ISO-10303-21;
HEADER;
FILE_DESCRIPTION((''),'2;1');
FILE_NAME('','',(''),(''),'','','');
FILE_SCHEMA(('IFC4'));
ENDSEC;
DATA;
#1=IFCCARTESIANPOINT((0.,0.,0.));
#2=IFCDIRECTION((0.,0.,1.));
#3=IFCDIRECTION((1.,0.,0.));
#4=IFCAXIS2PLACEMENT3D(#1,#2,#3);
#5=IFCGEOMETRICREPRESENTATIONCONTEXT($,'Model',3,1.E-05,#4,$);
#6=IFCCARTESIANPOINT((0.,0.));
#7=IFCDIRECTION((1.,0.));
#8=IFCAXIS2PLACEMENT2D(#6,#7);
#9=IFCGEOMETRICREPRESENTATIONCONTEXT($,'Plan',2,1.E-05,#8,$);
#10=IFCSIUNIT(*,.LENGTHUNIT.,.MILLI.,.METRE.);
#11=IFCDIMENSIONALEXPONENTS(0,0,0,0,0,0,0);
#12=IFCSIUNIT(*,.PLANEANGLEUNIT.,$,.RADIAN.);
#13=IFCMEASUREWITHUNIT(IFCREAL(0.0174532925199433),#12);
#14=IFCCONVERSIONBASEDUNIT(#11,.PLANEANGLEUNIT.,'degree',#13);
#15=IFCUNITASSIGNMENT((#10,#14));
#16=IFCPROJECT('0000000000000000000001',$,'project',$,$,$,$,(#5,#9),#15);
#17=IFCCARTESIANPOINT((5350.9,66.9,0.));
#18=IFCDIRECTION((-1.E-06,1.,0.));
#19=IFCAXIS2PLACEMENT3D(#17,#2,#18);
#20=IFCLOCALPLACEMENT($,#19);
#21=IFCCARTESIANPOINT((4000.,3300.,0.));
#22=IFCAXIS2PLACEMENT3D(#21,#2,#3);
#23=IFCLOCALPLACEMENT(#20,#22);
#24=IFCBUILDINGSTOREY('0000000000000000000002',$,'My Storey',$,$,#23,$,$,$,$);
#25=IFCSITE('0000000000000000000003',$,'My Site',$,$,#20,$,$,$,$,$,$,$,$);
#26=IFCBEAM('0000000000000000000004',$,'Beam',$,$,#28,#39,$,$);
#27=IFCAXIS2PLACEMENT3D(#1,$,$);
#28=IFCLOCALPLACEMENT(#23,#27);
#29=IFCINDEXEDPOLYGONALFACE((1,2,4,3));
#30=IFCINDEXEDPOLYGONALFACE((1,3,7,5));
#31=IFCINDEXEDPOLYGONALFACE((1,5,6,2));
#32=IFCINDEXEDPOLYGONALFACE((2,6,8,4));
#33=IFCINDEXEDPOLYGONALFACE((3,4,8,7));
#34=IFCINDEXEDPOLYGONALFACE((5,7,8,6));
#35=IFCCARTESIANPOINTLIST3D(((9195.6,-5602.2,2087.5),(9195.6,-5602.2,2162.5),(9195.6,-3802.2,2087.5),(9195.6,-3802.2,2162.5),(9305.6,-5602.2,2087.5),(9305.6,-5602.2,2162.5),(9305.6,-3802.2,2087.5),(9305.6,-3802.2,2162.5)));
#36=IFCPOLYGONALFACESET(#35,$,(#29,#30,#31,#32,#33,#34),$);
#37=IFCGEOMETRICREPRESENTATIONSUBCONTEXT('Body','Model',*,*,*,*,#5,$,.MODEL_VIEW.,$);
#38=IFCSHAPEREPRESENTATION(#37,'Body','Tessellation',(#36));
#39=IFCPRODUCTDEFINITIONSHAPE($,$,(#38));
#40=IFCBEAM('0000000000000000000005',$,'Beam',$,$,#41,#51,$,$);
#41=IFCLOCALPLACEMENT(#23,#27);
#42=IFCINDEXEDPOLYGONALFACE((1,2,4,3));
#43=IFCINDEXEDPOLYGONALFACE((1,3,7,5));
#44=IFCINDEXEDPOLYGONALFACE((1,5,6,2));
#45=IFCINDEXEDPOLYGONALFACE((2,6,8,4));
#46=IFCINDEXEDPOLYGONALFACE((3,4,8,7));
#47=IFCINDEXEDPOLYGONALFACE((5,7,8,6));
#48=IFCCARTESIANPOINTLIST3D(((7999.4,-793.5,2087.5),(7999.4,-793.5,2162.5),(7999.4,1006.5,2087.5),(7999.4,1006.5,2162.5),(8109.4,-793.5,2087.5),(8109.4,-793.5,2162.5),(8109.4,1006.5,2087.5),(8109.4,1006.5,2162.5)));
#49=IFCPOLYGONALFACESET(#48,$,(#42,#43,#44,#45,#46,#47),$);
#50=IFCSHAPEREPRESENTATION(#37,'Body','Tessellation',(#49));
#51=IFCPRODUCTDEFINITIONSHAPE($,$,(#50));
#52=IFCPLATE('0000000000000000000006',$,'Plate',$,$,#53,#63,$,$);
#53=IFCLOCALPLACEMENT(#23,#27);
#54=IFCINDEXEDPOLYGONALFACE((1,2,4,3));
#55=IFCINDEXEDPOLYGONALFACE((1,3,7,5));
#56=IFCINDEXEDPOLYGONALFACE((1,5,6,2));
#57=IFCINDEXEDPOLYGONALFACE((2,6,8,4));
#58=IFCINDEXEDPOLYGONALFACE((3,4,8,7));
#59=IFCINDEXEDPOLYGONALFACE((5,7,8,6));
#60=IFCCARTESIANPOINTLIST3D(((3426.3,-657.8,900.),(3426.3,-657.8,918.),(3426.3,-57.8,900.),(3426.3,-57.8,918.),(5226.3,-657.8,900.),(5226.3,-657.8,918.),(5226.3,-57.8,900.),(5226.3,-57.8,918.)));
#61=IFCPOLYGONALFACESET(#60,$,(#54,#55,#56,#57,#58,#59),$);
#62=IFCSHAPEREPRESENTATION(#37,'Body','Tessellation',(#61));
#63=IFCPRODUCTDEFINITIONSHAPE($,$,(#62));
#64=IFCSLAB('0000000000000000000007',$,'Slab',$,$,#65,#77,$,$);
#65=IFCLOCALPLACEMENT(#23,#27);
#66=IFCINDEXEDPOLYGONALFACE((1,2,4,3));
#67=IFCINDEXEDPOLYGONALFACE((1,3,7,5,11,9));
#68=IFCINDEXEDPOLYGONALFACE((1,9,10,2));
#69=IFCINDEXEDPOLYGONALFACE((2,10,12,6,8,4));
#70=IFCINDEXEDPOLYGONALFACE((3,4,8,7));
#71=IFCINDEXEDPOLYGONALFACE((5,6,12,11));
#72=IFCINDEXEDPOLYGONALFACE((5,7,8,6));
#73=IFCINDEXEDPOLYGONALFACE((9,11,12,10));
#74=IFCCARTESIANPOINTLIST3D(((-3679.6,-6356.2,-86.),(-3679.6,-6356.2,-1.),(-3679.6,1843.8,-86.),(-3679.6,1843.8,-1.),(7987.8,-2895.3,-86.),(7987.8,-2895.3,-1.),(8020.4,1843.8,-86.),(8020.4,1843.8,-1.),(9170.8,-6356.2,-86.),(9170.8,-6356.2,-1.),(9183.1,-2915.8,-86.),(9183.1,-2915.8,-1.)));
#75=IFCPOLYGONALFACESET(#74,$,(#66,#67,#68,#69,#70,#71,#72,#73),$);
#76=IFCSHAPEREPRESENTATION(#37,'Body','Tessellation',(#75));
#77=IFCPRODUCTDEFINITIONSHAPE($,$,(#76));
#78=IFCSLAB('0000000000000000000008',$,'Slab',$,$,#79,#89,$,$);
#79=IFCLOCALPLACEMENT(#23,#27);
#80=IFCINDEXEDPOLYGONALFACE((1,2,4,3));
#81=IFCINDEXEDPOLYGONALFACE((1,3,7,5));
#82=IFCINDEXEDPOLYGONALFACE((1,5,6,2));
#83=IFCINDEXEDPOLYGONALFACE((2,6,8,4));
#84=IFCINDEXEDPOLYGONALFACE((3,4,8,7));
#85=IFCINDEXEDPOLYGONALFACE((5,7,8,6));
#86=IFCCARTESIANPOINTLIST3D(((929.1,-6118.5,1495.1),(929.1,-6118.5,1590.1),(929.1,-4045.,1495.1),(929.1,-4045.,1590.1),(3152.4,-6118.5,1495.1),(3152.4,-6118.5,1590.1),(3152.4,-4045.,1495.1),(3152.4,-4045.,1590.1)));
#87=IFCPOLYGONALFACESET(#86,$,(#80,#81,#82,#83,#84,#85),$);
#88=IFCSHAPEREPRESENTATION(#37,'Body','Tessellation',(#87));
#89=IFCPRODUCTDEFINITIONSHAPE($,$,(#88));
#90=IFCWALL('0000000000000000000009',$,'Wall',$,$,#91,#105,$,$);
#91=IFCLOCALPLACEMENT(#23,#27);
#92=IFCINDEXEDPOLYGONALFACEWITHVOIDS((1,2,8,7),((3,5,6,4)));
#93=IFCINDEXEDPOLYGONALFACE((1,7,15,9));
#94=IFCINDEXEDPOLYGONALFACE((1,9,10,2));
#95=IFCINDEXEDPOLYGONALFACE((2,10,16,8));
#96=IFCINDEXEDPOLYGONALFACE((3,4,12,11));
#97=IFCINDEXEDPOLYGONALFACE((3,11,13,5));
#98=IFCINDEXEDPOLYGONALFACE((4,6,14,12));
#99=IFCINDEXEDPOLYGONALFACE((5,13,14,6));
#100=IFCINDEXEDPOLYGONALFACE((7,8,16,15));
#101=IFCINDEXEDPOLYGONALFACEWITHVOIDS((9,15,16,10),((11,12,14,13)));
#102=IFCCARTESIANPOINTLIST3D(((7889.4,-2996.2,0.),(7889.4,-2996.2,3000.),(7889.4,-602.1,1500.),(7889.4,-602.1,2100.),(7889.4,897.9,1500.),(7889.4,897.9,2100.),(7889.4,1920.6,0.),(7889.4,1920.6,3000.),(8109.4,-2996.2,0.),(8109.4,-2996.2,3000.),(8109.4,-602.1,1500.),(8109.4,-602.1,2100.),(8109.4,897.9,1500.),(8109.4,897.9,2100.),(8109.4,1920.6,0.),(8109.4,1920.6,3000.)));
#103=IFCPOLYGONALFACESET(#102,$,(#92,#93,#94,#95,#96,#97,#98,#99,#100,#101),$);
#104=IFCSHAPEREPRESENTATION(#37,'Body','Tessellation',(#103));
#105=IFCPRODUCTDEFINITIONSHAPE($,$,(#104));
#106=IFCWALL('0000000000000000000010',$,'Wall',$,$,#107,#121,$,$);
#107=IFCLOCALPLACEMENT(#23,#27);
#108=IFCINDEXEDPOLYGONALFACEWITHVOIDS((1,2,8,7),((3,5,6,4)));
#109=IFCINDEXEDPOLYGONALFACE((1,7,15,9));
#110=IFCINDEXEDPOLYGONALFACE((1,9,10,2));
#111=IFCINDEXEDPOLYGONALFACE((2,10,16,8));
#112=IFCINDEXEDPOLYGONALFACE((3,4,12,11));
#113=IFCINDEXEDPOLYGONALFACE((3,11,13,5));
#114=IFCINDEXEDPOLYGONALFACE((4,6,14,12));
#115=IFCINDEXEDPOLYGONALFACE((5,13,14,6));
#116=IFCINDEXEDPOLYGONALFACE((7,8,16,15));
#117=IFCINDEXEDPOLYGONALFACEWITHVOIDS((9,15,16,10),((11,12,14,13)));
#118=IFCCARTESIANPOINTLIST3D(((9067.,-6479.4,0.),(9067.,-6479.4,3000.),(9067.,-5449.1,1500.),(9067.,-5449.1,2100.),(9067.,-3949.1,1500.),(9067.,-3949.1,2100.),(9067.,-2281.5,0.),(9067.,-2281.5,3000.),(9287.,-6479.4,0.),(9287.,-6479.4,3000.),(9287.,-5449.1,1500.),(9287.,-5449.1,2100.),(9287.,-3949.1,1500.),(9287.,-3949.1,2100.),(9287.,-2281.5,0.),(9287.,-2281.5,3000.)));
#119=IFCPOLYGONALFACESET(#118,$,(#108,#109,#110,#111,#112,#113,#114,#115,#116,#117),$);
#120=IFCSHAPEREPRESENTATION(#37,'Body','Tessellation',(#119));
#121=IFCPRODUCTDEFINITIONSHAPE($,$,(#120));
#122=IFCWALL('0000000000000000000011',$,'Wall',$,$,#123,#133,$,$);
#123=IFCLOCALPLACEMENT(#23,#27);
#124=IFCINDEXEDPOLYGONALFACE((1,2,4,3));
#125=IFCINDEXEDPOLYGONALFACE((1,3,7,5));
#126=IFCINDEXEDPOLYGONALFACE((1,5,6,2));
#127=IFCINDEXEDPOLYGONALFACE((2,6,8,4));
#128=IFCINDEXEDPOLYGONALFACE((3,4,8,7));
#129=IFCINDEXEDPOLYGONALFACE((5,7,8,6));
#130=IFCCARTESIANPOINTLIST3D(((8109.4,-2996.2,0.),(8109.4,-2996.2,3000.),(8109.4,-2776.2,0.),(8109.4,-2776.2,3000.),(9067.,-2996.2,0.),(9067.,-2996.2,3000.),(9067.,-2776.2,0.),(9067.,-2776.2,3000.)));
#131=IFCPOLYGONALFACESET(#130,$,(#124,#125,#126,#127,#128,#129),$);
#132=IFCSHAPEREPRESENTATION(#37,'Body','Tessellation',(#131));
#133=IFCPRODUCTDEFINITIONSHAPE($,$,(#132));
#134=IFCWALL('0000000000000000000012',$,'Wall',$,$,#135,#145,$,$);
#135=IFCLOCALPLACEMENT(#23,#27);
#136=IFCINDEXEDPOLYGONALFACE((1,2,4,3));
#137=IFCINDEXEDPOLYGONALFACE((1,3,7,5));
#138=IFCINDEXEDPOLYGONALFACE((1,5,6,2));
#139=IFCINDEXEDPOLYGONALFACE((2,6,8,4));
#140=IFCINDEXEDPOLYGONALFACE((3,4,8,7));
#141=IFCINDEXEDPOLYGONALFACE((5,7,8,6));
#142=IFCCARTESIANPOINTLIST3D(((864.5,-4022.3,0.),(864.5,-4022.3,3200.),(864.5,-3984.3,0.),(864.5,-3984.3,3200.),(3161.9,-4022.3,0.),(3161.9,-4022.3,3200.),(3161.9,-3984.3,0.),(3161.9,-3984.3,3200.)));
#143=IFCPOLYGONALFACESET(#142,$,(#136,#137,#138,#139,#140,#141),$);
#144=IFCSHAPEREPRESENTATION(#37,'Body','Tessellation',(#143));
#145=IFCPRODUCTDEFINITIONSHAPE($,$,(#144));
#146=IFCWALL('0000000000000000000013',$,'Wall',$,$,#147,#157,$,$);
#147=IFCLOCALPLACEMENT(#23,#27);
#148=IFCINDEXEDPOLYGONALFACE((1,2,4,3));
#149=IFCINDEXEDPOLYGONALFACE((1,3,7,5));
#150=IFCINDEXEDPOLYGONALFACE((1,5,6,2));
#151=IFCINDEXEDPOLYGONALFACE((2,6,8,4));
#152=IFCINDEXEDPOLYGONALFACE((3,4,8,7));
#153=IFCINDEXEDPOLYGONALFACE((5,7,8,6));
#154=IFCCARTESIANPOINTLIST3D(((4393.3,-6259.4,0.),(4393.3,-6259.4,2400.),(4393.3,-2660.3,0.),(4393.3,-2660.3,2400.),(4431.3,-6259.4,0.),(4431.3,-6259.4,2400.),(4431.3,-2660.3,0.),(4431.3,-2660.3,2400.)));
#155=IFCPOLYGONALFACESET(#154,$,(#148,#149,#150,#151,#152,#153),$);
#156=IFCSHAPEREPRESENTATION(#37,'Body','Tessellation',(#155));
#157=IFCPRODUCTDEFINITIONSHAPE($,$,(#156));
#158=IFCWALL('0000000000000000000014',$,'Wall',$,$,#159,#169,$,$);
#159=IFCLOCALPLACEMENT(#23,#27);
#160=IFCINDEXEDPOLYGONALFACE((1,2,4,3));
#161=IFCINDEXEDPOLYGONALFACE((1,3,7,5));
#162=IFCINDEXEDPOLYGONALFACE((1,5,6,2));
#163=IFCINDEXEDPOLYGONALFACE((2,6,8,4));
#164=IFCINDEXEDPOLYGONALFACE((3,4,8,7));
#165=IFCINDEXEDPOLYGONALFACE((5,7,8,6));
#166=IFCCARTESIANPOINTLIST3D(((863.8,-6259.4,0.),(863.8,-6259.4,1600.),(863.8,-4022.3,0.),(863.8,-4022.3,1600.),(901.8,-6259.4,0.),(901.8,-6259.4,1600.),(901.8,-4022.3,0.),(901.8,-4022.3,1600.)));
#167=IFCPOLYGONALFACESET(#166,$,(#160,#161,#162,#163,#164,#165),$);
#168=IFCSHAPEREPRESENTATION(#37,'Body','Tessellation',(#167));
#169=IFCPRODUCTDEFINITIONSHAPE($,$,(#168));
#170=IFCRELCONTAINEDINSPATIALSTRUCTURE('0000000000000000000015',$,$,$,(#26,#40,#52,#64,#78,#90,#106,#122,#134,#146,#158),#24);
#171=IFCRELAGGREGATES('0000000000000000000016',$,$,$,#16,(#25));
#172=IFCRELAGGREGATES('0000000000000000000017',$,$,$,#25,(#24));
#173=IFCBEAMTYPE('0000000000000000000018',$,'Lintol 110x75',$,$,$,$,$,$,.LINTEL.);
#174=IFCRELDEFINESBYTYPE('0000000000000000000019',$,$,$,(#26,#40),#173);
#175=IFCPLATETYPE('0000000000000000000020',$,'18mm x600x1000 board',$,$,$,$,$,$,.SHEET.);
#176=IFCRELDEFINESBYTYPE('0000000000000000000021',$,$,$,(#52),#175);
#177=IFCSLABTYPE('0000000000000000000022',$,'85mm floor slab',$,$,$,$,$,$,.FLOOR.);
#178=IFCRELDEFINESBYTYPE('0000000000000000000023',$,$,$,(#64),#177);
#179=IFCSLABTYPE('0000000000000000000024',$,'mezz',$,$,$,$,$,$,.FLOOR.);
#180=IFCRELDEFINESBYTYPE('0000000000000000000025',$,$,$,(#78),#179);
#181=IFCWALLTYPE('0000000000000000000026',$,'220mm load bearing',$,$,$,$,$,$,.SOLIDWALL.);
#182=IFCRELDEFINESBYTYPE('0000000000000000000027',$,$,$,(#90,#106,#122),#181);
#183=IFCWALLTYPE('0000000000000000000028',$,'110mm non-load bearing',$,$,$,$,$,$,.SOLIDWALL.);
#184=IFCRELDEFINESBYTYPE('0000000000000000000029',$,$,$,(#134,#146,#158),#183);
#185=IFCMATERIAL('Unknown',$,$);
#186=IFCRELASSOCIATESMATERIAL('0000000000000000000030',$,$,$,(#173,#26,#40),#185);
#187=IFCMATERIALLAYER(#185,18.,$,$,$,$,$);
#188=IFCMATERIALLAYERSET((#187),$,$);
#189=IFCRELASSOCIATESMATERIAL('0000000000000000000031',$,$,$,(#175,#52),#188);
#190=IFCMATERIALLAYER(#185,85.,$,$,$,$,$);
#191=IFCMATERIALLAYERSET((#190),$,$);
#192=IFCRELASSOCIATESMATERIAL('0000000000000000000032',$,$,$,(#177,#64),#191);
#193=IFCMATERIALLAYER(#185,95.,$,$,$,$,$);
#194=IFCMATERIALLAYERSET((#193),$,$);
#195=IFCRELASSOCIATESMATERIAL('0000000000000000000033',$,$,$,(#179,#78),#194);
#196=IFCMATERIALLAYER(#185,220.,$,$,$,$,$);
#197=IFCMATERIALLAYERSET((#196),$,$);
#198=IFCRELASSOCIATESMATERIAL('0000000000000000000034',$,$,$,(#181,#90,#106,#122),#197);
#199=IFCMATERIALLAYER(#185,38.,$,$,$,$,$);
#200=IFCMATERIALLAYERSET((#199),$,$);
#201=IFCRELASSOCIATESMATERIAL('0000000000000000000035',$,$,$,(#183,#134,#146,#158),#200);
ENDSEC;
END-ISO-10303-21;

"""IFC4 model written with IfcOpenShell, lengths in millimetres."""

from ifc_helpers import new_model, entity, si_unit, converted_unit, frame, origin_with_axes, origin_2d_with_axis, place, context, subcontext, project, spatial, line, indexed_curve, rectangle, outline, extrude, source, transform, mapped, material, layer, layer_set, layer_usage, material_profile, profile_set, profile_usage, type_object, element, save


model = new_model("IFC4")

# Units and contexts
model_context = context("Model", 3, precision=1e-05, world=origin_with_axes())
plan_context = context("Plan", 2, precision=1e-05, world=origin_2d_with_axis())
body_context = subcontext(model_context, "Body", "Model", "MODEL_VIEW")
ifc_project = project(units=[si_unit("LENGTHUNIT", "METRE", prefix="MILLI"), converted_unit("PLANEANGLEUNIT", "degree", entity("IfcReal", 0.0174532925199433), si_unit("PLANEANGLEUNIT", "RADIAN"), dimensions=[0, 0, 0, 0, 0, 0, 0])], contexts=[model_context, plan_context])

# Site, storey
site_placement = place(None, frame((5350.9, 66.9, 0.0), z_axis=(0.0, 0.0, 1.0), x_axis=(-0.000001, 1.0, 0.0)))
site = spatial("IfcSite", under=ifc_project, at=site_placement, Name="My Site")
storey_placement = place(site_placement, frame((4000.0, 3300.0, 0.0), z_axis=(0.0, 0.0, 1.0), x_axis=(1.0, 0.0, 0.0)))
storey = spatial("IfcBuildingStorey", under=site, at=storey_placement, Name="My Storey")

# Beams
ifc_material = material(Name="Unknown")
ifc_material_profile = material_profile(ifc_material, rectangle(XDim=110.0, YDim=75.0))
ifc_profile_set = profile_set([ifc_material_profile])
ifc_profile_usage_1 = profile_usage(ifc_profile_set, cardinal=5)
beam_type = type_object("IfcBeamType", Name="Lintol 110x75", PredefinedType="LINTEL", material=ifc_profile_set)
beam_1_placement = place(storey_placement, frame((9250.6, -3802.2, 2125.0), z_axis=(-0.000001, -1.0, 0.0), x_axis=(1.0, -0.000001, 0.0)))
element("IfcBeam", 1, at=beam_1_placement, inside=storey, type_object=beam_type, material=ifc_profile_usage_1, Name="Beam", context=body_context, shape_type="SweptSolid", body=[
    extrude(rectangle(XDim=110.0, YDim=75.0), origin_with_axes(), (0.0, 0.0, 1.0), 1800.0),
])
ifc_profile_usage_2 = profile_usage(ifc_profile_set, cardinal=5)
beam_2_placement = place(storey_placement, frame((8054.4, 1006.5, 2125.0), z_axis=(-0.000001, -1.0, 0.0), x_axis=(1.0, -0.000001, 0.0)))
element("IfcBeam", 2, at=beam_2_placement, inside=storey, type_object=beam_type, material=ifc_profile_usage_2, Name="Beam", context=body_context, shape_type="SweptSolid", body=[
    extrude(rectangle(XDim=110.0, YDim=75.0), origin_with_axes(), (0.0, 0.0, 1.0), 1800.0),
])

# Plate
ifc_layer_1 = layer(ifc_material, 18.0)
ifc_layer_set_1 = layer_set([ifc_layer_1])
plate_type = type_object("IfcPlateType", Name="18mm x600x1000 board", PredefinedType="SHEET", material=ifc_layer_set_1)
ifc_layer_usage_1 = layer_usage(ifc_layer_set_1, "AXIS3", "POSITIVE", 0.0)
plate_1_placement = place(storey_placement, frame((3426.3, -57.8, 900.0), z_axis=(0.0, 0.0, 1.0), x_axis=(0.0, -1.0, 0.0)))
element("IfcPlate", 3, at=plate_1_placement, inside=storey, type_object=plate_type, material=ifc_layer_usage_1, Name="Plate", context=body_context, shape_type="SweptSolid", body=[
    extrude(outline(indexed_curve([(0.0, 1800.0), (600.0, 1800.0), (600.0, 0.0), (0.0, 0.0)], segments=[line(3, 2), line(2, 1), line(1, 4), line(4, 3)], self_intersect=False)), None, (0.0, 0.0, 1.0), 18.0),
])

# Slabs
ifc_layer_2 = layer(ifc_material, 85.0)
ifc_layer_set_2 = layer_set([ifc_layer_2])
ifc_layer_usage_2 = layer_usage(ifc_layer_set_2, "AXIS3", "POSITIVE", 0.0)
slab_type_1 = type_object("IfcSlabType", Name="85mm floor slab", PredefinedType="FLOOR", material=ifc_layer_set_2)
slab_1_placement = place(storey_placement, frame((8020.4, 1843.8, -86.0), z_axis=(0.0, 0.0, 1.0), x_axis=(-1.0, 0.000001, 0.0)))
element("IfcSlab", 4, at=slab_1_placement, inside=storey, type_object=slab_type_1, material=ifc_layer_usage_2, Name="Slab", context=body_context, shape_type="SweptSolid", body=[
    extrude(outline(indexed_curve([(-1150.4, 8200.0), (11700.0, 8200.0), (11700.0, 0.0), (0.0, 0.0), (32.6, 4739.0), (-1162.7, 4759.6)], segments=[line(4, 5), line(5, 6), line(6, 1), line(1, 2), line(2, 3), line(3, 4)], self_intersect=False)), None, (0.0, 0.0, 1.0), 85.0),
])
ifc_layer_3 = layer(ifc_material, 95.0)
ifc_layer_set_3 = layer_set([ifc_layer_3])
ifc_layer_usage_3 = layer_usage(ifc_layer_set_3, "AXIS3", "POSITIVE", 0.0)
slab_type_2 = type_object("IfcSlabType", Name="mezz", PredefinedType="FLOOR", material=ifc_layer_set_3)
slab_2_placement = place(storey_placement, frame((929.1, -6118.5, 1495.1), z_axis=(0.0, 0.0, 1.0), x_axis=(1.0, 0.0, 0.0)))
element("IfcSlab", 5, at=slab_2_placement, inside=storey, type_object=slab_type_2, material=ifc_layer_usage_3, Name="Slab", context=body_context, shape_type="SweptSolid", body=[
    extrude(outline(indexed_curve([(2223.3, 2073.5), (2223.3, 0.0), (0.0, 0.0), (0.0, 2073.5)], segments=[line(3, 2), line(2, 1), line(1, 4), line(4, 3)], self_intersect=False)), None, (0.0, 0.0, 1.0), 95.0),
])

# Walls, openings
ifc_layer_4 = layer(ifc_material, 220.0)
ifc_layer_set_4 = layer_set([ifc_layer_4])
ifc_layer_usage_4 = layer_usage(ifc_layer_set_4, "AXIS2", "POSITIVE", 0.0)
wall_type_1 = type_object("IfcWallType", Name="220mm load bearing", PredefinedType="SOLIDWALL", material=ifc_layer_set_4)
wall_1_placement = place(storey_placement, frame((8109.4, -2996.2, 0.0), z_axis=(0.0, 0.0, 1.0), x_axis=(0.0, 1.0, 0.0)))
wall_1 = element("IfcWall", 6, at=wall_1_placement, inside=storey, type_object=wall_type_1, material=ifc_layer_usage_4, Name="Wall", context=body_context, shape_type="SweptSolid", body=[
    extrude(outline(indexed_curve([(0.0, 0.0), (0.0, 220.0), (4916.8, 220.0), (4916.8, 0.0), (0.0, 0.0)], self_intersect=False)), origin_with_axes(), (0.0, 0.0, 1.0), 3000.0),
])
shared_shape = source(origin_with_axes(), body_context, "Body", "SweptSolid", [
    extrude(outline(indexed_curve([(0.0, 0.0), (1500.0, 0.0), (1500.0, 600.0), (0.0, 600.0)], segments=[line(1, 2, 3, 4, 1)])), frame((0.0, -100.0, 0.0), z_axis=(0.0, -1.0, 0.0), x_axis=(1.0, 0.0, 0.0)), (0.0, 0.0, -1.0), 420.0),
])
opening_1_placement = place(wall_1_placement, frame((2394.1, -77.5, 1500.0), z_axis=(0.0, 0.0, 1.0), x_axis=(1.0, 0.0, 0.0)))
element("IfcOpeningElement", 7, at=opening_1_placement, cuts=wall_1, PredefinedType="OPENING", context=body_context, shape_type="MappedRepresentation", body=[
    mapped(shared_shape, transform((0.0, 0.0, 0.0), x_axis=(1.0, 0.0, 0.0), y_axis=(0.0, 1.0, 0.0), z_axis=(0.0, 0.0, 1.0), scale=1.0)),
])
ifc_layer_usage_5 = layer_usage(ifc_layer_set_4, "AXIS2", "POSITIVE", 0.0)
wall_2_placement = place(storey_placement, frame((9067.0, -2281.5, 0.0), z_axis=(0.0, 0.0, 1.0), x_axis=(-0.000001, -1.0, 0.0)))
wall_2 = element("IfcWall", 8, at=wall_2_placement, inside=storey, type_object=wall_type_1, material=ifc_layer_usage_5, Name="Wall", context=body_context, shape_type="SweptSolid", body=[
    extrude(outline(indexed_curve([(0.0, 0.0), (0.0, 220.0), (4197.9, 220.0), (4197.9, 0.0), (0.0, 0.0)], self_intersect=False)), origin_with_axes(), (0.0, 0.0, 1.0), 3000.0),
])
opening_2_placement = place(wall_2_placement, frame((1667.6, 0.0, 1500.0), z_axis=(0.0, 0.0, 1.0), x_axis=(1.0, 0.0, 0.0)))
element("IfcOpeningElement", 9, at=opening_2_placement, cuts=wall_2, PredefinedType="OPENING", context=body_context, shape_type="MappedRepresentation", body=[
    mapped(shared_shape, transform((0.0, 0.0, 0.0), x_axis=(1.0, 0.0, 0.0), y_axis=(0.0, 1.0, 0.0), z_axis=(0.0, 0.0, 1.0), scale=1.0)),
])

# Walls
ifc_layer_usage_6 = layer_usage(ifc_layer_set_4, "AXIS2", "POSITIVE", 0.0)
wall_3_placement = place(storey_placement, frame((8109.4, -2996.2, 0.0), z_axis=(0.0, 0.0, 1.0), x_axis=(1.0, -0.000001, 0.0)))
element("IfcWall", 10, at=wall_3_placement, inside=storey, type_object=wall_type_1, material=ifc_layer_usage_6, Name="Wall", context=body_context, shape_type="SweptSolid", body=[
    extrude(outline(indexed_curve([(0.0, 0.0), (0.0, 220.0), (957.5, 220.0), (957.5, 0.0), (0.0, 0.0)], self_intersect=False)), origin_with_axes(), (0.0, 0.0, 1.0), 3000.0),
])
ifc_layer_5 = layer(ifc_material, 38.0)
ifc_layer_set_5 = layer_set([ifc_layer_5])
ifc_layer_usage_7 = layer_usage(ifc_layer_set_5, "AXIS2", "POSITIVE", 0.0)
wall_type_2 = type_object("IfcWallType", Name="110mm non-load bearing", PredefinedType="SOLIDWALL", material=ifc_layer_set_5)
wall_4_placement = place(storey_placement, frame((3161.9, -3984.3, 0.0), z_axis=(0.0, 0.0, 1.0), x_axis=(-1.0, 0.000001, 0.0)))
element("IfcWall", 11, at=wall_4_placement, inside=storey, type_object=wall_type_2, material=ifc_layer_usage_7, Name="Wall", context=body_context, shape_type="SweptSolid", body=[
    extrude(outline(indexed_curve([(0.0, 0.0), (0.0, 38.0), (2297.5, 38.0), (2297.5, 0.0), (0.0, 0.0)], self_intersect=False)), origin_with_axes(), (0.0, 0.0, 1.0), 3200.0),
])
ifc_layer_usage_8 = layer_usage(ifc_layer_set_5, "AXIS2", "POSITIVE", 0.0)
wall_5_placement = place(storey_placement, frame((4431.3, -6259.4, 0.0), z_axis=(0.0, 0.0, 1.0), x_axis=(0.000001, 1.0, 0.0)))
element("IfcWall", 12, at=wall_5_placement, inside=storey, type_object=wall_type_2, material=ifc_layer_usage_8, Name="Wall", context=body_context, shape_type="SweptSolid", body=[
    extrude(outline(indexed_curve([(0.0, 0.0), (0.0, 38.0), (3599.1, 38.0), (3599.1, 0.0), (0.0, 0.0)], self_intersect=False)), origin_with_axes(), (0.0, 0.0, 1.0), 2400.0),
])
ifc_layer_usage_9 = layer_usage(ifc_layer_set_5, "AXIS2", "POSITIVE", 0.0)
wall_6_placement = place(storey_placement, frame((901.8, -6259.4, 0.0), z_axis=(0.0, 0.0, 1.0), x_axis=(0.000001, 1.0, 0.0)))
element("IfcWall", 13, at=wall_6_placement, inside=storey, type_object=wall_type_2, material=ifc_layer_usage_9, Name="Wall", context=body_context, shape_type="SweptSolid", body=[
    extrude(outline(indexed_curve([(0.0, 0.0), (0.0, 38.0), (2237.1, 38.0), (2237.1, 0.0), (0.0, 0.0)], self_intersect=False)), origin_with_axes(), (0.0, 0.0, 1.0), 1600.0),
])

save(model, "model.ifc")
